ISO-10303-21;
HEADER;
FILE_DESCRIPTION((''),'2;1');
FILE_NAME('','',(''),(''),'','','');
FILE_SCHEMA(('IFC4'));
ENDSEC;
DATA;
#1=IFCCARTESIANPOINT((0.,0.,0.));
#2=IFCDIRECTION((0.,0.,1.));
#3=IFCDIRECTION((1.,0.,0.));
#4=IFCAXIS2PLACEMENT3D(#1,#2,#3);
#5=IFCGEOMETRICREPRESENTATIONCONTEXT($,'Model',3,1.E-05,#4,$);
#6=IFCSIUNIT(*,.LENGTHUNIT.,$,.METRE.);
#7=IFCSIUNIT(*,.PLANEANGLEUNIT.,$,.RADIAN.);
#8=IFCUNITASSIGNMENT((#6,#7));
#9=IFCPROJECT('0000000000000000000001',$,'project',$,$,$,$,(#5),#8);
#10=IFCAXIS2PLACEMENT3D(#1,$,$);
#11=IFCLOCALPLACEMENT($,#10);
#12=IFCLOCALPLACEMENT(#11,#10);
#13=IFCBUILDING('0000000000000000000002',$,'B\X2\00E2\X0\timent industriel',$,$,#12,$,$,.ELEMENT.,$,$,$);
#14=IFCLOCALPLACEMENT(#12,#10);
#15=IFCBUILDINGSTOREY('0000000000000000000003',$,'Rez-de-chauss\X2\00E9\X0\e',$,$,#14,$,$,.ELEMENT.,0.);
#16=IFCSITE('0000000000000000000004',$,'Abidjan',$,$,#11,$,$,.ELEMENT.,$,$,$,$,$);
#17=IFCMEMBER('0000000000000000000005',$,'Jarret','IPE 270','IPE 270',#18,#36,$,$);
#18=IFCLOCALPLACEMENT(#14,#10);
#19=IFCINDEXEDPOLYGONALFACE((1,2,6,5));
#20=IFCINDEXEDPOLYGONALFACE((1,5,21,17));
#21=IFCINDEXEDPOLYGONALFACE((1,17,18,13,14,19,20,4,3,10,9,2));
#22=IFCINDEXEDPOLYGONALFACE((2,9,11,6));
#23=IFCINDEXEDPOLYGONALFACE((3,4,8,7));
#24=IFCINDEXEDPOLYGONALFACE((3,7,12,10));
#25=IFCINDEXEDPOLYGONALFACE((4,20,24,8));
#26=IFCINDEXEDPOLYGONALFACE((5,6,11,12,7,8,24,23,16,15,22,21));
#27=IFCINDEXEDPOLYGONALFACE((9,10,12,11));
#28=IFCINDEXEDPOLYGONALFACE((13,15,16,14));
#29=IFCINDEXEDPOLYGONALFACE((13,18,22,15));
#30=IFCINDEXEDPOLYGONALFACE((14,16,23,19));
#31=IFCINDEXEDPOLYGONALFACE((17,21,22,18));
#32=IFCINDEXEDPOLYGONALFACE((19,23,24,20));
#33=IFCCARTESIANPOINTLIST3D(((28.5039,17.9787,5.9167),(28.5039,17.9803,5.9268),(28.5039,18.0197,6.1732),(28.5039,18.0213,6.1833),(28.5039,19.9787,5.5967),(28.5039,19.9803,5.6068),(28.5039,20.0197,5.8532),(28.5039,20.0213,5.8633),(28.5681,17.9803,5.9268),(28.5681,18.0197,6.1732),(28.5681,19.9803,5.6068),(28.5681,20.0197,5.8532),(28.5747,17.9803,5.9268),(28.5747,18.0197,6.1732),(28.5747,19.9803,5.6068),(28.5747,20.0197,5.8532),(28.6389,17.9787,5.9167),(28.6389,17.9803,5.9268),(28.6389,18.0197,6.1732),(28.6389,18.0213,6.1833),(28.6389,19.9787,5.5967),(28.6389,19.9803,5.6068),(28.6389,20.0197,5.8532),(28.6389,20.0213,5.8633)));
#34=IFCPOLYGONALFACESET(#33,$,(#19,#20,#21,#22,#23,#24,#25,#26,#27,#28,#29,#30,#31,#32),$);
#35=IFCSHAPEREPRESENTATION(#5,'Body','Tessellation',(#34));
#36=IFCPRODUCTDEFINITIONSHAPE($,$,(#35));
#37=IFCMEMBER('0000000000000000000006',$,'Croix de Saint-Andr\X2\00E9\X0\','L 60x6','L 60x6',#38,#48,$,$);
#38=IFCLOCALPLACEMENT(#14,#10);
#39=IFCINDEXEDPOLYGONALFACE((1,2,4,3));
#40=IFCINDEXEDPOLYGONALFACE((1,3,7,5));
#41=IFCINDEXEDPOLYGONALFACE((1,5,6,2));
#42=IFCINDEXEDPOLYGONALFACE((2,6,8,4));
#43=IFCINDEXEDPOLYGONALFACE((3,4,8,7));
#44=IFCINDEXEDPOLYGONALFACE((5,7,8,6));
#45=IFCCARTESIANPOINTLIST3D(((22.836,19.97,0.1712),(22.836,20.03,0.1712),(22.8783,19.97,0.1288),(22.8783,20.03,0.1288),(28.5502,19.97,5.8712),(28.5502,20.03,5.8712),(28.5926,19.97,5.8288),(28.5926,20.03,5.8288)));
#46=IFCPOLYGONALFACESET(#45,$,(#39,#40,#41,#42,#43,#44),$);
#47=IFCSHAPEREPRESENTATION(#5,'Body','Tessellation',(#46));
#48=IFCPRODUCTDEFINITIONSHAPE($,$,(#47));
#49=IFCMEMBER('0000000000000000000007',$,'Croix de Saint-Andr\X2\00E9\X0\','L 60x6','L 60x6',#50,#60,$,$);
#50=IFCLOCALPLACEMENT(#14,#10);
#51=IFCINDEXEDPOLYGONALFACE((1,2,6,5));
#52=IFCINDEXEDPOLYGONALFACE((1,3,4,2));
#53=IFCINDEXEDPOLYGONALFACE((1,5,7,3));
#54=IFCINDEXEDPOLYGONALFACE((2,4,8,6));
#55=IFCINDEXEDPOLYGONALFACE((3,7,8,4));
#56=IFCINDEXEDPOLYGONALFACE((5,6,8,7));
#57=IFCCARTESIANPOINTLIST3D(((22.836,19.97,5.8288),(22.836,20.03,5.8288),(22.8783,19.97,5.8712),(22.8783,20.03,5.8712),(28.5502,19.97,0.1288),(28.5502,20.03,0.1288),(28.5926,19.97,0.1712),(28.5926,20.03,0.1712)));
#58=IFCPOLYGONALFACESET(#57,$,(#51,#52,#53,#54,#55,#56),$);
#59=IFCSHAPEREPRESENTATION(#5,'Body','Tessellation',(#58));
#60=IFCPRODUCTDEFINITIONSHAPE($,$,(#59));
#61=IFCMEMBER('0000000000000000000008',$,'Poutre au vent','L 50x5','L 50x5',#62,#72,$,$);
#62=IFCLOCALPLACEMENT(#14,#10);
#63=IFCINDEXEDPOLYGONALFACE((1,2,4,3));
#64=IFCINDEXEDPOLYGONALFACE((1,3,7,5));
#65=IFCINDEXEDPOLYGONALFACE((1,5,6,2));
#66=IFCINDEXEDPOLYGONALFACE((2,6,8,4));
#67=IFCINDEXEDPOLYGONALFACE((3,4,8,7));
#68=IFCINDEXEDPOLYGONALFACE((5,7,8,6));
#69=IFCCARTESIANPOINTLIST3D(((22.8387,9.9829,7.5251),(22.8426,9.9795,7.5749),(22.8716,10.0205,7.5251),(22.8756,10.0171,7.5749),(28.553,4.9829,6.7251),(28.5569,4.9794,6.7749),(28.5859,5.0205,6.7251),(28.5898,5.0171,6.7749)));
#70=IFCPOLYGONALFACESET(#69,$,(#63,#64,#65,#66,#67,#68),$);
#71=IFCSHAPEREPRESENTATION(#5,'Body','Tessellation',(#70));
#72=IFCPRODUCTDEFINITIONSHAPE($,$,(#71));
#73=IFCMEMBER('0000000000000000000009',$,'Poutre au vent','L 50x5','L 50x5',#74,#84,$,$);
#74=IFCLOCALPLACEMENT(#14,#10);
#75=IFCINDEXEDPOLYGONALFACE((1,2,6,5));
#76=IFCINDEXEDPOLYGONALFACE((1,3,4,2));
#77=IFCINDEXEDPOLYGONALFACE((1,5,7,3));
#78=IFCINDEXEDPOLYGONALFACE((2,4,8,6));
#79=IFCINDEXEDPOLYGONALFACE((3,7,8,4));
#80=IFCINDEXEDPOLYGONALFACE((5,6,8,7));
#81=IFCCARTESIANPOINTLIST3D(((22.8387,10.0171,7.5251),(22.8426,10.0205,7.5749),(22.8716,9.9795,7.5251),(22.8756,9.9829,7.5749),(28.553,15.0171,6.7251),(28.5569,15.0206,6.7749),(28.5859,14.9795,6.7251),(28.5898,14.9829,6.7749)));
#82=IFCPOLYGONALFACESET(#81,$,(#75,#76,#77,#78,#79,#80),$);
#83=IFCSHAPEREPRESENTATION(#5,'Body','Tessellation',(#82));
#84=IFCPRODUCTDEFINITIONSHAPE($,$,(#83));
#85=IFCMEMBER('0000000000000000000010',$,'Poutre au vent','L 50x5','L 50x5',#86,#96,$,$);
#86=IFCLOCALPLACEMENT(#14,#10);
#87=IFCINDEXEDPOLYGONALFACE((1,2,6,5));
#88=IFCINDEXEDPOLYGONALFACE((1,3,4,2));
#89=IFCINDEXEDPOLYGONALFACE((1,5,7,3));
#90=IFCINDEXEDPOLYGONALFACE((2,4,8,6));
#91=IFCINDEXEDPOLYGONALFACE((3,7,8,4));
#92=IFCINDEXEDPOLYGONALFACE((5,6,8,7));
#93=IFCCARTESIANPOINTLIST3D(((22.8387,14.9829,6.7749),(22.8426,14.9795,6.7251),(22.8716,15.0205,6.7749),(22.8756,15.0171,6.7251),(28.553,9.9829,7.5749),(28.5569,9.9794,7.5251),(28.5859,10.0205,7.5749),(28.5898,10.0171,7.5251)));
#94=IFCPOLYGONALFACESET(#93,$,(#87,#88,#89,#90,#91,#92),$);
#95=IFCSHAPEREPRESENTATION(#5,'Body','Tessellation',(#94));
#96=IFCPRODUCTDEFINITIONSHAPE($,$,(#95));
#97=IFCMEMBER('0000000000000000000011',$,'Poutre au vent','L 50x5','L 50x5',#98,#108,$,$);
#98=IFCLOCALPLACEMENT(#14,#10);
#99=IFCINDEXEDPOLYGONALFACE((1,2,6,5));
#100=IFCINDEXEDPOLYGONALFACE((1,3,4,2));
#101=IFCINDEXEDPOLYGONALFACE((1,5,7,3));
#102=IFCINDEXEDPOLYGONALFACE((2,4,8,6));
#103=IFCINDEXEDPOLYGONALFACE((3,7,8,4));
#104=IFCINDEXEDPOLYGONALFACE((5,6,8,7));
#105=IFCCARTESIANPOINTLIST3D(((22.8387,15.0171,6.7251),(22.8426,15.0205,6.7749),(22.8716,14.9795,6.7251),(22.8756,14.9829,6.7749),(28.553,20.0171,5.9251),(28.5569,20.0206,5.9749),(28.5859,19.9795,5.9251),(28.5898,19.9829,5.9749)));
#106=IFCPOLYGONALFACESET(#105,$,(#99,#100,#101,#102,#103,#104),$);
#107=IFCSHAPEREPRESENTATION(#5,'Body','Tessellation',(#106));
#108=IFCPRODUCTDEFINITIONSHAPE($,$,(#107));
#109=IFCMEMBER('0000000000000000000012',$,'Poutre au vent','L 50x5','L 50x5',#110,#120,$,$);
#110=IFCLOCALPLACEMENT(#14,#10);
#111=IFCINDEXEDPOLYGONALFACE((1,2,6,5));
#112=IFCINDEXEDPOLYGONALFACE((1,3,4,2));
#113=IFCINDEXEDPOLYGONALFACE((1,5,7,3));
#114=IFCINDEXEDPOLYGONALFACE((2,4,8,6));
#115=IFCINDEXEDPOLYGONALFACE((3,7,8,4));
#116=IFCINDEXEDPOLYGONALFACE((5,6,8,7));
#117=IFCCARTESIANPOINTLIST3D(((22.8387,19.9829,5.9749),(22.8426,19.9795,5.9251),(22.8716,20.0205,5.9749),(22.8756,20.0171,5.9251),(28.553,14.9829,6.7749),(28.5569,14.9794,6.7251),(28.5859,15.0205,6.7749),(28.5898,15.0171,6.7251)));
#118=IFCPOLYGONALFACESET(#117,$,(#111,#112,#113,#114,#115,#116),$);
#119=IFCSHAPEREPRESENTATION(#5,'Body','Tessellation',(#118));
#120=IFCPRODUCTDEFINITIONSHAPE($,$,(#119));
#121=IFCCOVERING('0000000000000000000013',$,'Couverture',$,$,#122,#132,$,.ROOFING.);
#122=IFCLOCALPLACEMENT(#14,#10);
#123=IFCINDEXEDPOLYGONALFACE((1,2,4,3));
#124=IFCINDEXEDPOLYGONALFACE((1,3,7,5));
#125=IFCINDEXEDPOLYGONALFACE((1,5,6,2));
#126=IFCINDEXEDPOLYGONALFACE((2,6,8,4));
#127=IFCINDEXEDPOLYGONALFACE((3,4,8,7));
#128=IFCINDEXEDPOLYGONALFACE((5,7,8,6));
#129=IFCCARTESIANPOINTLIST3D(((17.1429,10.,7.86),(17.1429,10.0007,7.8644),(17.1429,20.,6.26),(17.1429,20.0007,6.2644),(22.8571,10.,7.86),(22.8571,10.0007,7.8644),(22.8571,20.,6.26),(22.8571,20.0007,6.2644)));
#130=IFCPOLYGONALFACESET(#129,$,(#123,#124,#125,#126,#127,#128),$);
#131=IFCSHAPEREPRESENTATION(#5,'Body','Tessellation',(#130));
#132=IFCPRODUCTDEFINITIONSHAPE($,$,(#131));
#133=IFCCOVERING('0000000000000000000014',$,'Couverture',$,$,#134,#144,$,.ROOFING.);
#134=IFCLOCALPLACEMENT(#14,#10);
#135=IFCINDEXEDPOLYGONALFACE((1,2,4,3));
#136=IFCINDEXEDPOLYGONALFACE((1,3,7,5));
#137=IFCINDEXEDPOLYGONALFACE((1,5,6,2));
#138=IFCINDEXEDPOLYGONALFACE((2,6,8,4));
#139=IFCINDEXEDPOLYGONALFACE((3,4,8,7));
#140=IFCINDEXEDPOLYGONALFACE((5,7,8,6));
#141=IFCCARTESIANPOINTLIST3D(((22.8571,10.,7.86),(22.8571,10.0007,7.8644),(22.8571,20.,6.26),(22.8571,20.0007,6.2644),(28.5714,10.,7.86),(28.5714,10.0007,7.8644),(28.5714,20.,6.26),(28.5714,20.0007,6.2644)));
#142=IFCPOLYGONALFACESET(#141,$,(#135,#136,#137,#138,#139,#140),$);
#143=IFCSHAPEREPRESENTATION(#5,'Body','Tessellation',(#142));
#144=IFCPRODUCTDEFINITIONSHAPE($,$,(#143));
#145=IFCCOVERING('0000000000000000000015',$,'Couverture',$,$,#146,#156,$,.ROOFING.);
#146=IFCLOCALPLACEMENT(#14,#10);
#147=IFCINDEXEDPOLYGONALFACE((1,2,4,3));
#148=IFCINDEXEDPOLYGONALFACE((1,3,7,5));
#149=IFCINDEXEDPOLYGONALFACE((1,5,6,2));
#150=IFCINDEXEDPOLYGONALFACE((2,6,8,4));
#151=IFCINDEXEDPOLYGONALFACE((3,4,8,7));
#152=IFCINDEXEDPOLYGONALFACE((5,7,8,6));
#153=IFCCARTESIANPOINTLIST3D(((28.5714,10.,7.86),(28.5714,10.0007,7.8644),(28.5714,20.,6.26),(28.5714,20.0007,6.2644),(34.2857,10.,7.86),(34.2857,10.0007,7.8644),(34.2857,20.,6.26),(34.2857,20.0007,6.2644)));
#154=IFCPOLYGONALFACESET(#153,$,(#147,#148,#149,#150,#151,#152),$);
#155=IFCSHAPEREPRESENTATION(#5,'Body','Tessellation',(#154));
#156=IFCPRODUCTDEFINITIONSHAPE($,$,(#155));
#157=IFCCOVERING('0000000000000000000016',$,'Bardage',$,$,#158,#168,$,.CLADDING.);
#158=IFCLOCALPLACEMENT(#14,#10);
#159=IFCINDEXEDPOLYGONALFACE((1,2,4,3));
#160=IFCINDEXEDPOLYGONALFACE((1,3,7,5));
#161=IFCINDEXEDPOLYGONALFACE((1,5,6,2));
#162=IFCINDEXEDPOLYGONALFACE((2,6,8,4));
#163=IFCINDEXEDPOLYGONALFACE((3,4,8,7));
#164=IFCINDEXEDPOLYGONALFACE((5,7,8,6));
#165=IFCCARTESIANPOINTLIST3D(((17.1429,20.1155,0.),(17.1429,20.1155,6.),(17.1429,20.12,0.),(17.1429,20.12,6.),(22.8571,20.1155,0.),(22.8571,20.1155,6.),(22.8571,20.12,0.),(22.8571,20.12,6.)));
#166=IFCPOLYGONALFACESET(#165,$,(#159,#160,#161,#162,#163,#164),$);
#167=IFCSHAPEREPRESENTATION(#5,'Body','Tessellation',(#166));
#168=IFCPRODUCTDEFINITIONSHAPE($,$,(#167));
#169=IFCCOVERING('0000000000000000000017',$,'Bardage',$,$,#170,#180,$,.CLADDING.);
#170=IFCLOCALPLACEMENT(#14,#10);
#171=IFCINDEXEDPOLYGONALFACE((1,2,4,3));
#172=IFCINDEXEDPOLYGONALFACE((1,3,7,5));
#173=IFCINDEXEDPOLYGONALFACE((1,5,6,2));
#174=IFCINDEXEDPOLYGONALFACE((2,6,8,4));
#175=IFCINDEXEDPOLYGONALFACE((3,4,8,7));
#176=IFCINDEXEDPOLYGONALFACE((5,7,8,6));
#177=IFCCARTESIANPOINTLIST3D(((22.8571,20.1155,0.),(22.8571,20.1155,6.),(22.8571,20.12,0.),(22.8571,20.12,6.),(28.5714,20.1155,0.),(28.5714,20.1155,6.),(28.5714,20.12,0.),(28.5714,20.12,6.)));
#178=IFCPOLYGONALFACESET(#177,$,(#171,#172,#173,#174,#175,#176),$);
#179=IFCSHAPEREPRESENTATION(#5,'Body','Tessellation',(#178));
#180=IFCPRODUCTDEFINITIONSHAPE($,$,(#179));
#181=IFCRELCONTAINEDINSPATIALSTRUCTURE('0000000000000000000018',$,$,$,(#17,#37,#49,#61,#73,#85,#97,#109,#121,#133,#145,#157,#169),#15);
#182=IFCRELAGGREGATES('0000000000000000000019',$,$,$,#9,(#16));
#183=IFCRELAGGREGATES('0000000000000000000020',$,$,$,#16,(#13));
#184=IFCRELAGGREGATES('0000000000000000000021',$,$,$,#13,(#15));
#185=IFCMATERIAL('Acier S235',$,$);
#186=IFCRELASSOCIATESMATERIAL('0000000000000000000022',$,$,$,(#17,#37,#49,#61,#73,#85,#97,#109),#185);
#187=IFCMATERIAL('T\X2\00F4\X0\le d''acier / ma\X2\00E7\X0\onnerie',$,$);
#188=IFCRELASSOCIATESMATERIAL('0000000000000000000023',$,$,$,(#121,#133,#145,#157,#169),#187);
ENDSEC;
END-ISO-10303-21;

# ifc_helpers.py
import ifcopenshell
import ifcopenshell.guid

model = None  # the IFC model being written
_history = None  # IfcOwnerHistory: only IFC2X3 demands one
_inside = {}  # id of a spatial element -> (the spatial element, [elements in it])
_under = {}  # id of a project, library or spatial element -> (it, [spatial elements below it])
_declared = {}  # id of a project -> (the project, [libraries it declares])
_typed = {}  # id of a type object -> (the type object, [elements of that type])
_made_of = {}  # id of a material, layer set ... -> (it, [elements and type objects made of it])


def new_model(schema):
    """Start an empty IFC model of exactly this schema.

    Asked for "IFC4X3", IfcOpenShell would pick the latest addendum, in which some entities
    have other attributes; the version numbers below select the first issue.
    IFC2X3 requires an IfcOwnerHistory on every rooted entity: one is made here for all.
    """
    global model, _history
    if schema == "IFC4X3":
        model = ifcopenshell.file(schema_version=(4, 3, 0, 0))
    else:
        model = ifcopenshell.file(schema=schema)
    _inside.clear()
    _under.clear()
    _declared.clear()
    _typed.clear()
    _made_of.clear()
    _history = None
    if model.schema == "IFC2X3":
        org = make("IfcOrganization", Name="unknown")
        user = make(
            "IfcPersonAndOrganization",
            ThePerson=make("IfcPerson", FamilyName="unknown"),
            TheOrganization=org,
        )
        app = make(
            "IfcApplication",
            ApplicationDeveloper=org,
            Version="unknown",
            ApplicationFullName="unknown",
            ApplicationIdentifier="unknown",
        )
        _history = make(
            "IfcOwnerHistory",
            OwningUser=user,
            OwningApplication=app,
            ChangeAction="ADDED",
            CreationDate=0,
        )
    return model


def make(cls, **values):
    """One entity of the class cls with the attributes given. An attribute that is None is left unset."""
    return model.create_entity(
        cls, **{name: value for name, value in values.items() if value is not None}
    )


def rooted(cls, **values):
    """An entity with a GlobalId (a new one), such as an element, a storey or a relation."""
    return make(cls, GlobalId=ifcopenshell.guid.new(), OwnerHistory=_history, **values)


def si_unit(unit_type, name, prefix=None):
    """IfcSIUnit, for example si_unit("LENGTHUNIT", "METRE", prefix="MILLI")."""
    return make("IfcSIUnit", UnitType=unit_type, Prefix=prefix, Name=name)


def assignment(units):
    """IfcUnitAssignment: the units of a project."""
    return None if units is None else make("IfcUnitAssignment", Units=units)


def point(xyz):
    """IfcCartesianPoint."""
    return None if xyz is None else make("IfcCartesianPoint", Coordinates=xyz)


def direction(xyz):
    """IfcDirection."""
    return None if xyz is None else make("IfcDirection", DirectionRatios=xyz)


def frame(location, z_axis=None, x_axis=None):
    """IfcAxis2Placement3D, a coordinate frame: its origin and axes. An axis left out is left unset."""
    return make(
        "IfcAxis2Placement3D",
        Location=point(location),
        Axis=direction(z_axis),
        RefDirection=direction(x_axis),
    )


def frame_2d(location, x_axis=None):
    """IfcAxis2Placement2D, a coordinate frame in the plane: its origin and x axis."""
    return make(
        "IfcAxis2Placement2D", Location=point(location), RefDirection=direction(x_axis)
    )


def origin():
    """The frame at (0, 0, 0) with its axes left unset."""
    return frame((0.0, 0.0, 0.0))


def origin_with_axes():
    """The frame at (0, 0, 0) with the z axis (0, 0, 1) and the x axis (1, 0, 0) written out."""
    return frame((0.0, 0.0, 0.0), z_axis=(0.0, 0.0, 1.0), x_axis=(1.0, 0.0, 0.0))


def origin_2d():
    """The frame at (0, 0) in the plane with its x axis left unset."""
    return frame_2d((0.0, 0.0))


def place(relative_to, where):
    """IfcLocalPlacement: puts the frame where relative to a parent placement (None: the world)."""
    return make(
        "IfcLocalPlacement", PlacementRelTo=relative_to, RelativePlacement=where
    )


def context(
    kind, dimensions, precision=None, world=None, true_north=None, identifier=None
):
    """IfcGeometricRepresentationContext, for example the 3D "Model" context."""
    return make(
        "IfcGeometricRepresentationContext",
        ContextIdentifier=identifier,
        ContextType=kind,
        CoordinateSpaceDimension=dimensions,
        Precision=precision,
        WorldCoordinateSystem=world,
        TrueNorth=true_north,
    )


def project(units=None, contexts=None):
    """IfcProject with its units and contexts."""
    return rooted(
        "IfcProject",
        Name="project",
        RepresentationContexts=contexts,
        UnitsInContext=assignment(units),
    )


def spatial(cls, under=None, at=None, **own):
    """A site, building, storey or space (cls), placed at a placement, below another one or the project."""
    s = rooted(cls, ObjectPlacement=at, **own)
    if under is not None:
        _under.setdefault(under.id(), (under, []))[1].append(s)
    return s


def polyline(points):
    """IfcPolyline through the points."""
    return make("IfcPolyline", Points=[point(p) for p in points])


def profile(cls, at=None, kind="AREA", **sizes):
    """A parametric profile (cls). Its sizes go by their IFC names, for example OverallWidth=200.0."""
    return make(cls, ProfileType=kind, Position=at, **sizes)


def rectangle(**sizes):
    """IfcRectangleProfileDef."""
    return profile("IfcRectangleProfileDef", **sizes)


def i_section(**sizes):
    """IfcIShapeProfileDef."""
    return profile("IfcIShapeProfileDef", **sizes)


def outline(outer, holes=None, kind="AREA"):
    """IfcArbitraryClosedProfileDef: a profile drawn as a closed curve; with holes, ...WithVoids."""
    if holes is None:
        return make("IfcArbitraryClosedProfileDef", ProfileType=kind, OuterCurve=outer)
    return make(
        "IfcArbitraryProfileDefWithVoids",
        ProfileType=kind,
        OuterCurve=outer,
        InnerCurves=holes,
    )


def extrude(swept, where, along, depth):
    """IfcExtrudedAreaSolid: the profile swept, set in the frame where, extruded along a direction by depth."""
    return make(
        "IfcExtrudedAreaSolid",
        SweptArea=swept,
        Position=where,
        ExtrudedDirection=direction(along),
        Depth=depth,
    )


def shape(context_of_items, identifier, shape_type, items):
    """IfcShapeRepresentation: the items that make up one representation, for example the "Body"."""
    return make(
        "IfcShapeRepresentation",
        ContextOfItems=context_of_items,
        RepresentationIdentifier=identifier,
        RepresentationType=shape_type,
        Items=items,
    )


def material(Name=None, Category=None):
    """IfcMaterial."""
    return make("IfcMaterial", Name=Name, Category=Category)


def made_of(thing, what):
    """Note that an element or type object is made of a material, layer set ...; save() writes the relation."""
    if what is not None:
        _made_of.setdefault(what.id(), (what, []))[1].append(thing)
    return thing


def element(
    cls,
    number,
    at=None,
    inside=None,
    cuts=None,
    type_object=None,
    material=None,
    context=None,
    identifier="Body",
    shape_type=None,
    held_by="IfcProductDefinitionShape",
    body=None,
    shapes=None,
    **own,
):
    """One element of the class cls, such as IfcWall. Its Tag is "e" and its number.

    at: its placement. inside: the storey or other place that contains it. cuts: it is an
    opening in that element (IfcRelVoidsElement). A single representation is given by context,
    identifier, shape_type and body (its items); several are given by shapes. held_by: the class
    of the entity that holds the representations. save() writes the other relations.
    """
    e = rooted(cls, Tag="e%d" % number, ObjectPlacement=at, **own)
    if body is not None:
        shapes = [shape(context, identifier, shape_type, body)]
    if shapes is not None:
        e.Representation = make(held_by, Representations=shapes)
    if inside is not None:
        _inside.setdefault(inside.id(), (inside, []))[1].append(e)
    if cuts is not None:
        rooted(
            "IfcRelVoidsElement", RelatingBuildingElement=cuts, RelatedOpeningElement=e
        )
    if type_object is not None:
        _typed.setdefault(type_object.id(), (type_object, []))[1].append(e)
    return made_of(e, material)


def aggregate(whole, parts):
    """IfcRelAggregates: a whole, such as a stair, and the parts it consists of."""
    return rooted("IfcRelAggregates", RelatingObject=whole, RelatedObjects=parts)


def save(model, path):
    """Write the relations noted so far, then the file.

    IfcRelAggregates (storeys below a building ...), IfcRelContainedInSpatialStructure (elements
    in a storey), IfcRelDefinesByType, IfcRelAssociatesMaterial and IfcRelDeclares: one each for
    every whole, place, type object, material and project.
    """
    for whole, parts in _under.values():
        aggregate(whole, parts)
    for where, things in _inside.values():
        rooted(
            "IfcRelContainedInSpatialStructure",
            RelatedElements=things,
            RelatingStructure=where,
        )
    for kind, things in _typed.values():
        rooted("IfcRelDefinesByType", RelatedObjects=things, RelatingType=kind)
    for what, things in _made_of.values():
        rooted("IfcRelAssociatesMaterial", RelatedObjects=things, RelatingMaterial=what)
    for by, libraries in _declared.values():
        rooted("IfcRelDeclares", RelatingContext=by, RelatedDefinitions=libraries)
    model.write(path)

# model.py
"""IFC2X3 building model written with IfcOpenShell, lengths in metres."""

from ifc_helpers import new_model, si_unit, frame, origin, origin_with_axes, origin_2d, place, context, project, spatial, polyline, rectangle, i_section, outline, extrude, material, element, save


model = new_model("IFC2X3")

# Units and contexts
model_context = context("Model", 3, precision=1e-05, world=origin_with_axes())
ifc_project = project(units=[si_unit("LENGTHUNIT", "METRE"), si_unit("PLANEANGLEUNIT", "RADIAN")], contexts=[model_context])

# Site, building, storey
site_placement = place(None, origin())
site = spatial("IfcSite", under=ifc_project, at=site_placement, Name="Abidjan", CompositionType="ELEMENT")
building_placement = place(site_placement, origin())
building = spatial("IfcBuilding", under=site, at=building_placement, Name="Bâtiment industriel", CompositionType="ELEMENT")
storey_placement = place(building_placement, origin())
storey = spatial("IfcBuildingStorey", under=building, at=storey_placement, Name="Rez-de-chaussée", CompositionType="ELEMENT", Elevation=0.0)

# Shared definitions
ifc_material_1 = material(Name="Acier S235")

# Members
member_1_placement = place(storey_placement, frame((28.5714, 20.0, 5.73), z_axis=(0.0, -0.98744, 0.15799), x_axis=(1.0, 0.0, 0.0)))
element("IfcMember", 1, at=member_1_placement, inside=storey, material=ifc_material_1, Name="Jarret", Description="IPE 270", ObjectType="IPE 270", context=model_context, shape_type="SweptSolid", body=[
    extrude(i_section(OverallWidth=0.135, OverallDepth=0.27, WebThickness=0.0066, FlangeThickness=0.0102, at=origin_2d()), origin(), (0.0, 0.0, 1.0), 2.0254),
])
for number, where, z_axis, x_axis, name in (
    (2, (22.8571, 20.0, 0.15), (0.70799, 0.0, 0.70622), (0.0, 1.0, 0.0), "Croix de Saint-André"),
    (3, (28.5714, 20.0, 0.15), (-0.70799, 0.0, 0.70622), (0.0, 1.0, 0.0), "Croix de Saint-André"),
):
    element("IfcMember", number, at=place(storey_placement, frame(where, z_axis=z_axis, x_axis=x_axis)), inside=storey, material=ifc_material_1, Name=name, Description="L 60x6", ObjectType="L 60x6", context=model_context, shape_type="SweptSolid", body=[
        extrude(rectangle(XDim=0.06, YDim=0.06, at=origin_2d()), origin(), (0.0, 0.0, 1.0), 8.0711),
    ])
for number, where, z_axis, x_axis, name in (
    (4, (22.8571, 10.0, 7.55), (0.74843, -0.65488, -0.10478), (0.07886, -0.069, 0.9945), "Poutre au vent"),
    (5, (22.8571, 10.0, 7.55), (0.74843, 0.65488, -0.10478), (0.07886, 0.069, 0.9945), "Poutre au vent"),
    (6, (22.8571, 15.0, 6.75), (0.74843, -0.65488, 0.10478), (-0.07886, 0.069, 0.9945), "Poutre au vent"),
    (7, (22.8571, 15.0, 6.75), (0.74843, 0.65488, -0.10478), (0.07886, 0.069, 0.9945), "Poutre au vent"),
    (8, (22.8571, 20.0, 5.95), (0.74843, -0.65488, 0.10478), (-0.07886, 0.069, 0.9945), "Poutre au vent"),
):
    element("IfcMember", number, at=place(storey_placement, frame(where, z_axis=z_axis, x_axis=x_axis)), inside=storey, material=ifc_material_1, Name=name, Description="L 50x5", ObjectType="L 50x5", context=model_context, shape_type="SweptSolid", body=[
        extrude(rectangle(XDim=0.05, YDim=0.05, at=origin_2d()), origin(), (0.0, 0.0, 1.0), 7.635),
    ])

# Coverings
ifc_material_2 = material(Name="Tôle d'acier / maçonnerie")
for number, where, z_axis, x_axis, name in (
    (9, (17.1429, 10.0, 7.86), (0.0, 0.15799, 0.98744), (1.0, 0.0, 0.0), "Couverture"),
    (10, (22.8571, 10.0, 7.86), (0.0, 0.15799, 0.98744), (1.0, 0.0, 0.0), "Couverture"),
    (11, (28.5714, 10.0, 7.86), (0.0, 0.15799, 0.98744), (1.0, 0.0, 0.0), "Couverture"),
):
    element("IfcCovering", number, at=place(storey_placement, frame(where, z_axis=z_axis, x_axis=x_axis)), inside=storey, material=ifc_material_2, Name=name, PredefinedType="ROOFING", context=model_context, shape_type="SweptSolid", body=[
        extrude(outline(polyline([(0.0, 0.0), (5.7143, 0.0), (5.7143, 10.1272), (0.0, 10.1272), (0.0, 0.0)])), origin(), (0.0, 0.0, 1.0), 0.0045),
    ])
for number, where, z_axis, x_axis, name in (
    (12, (17.1429, 20.12, 0.0), (0.0, -1.0, 0.0), (1.0, 0.0, 0.0), "Bardage"),
    (13, (22.8571, 20.12, 0.0), (0.0, -1.0, 0.0), (1.0, 0.0, 0.0), "Bardage"),
):
    element("IfcCovering", number, at=place(storey_placement, frame(where, z_axis=z_axis, x_axis=x_axis)), inside=storey, material=ifc_material_2, Name=name, PredefinedType="CLADDING", context=model_context, shape_type="SweptSolid", body=[
        extrude(outline(polyline([(0.0, 0.0), (5.7143, 0.0), (5.7143, 6.0), (0.0, 6.0), (0.0, 0.0)])), origin(), (0.0, 0.0, 1.0), 0.0045),
    ])

save(model, "model.ifc")
